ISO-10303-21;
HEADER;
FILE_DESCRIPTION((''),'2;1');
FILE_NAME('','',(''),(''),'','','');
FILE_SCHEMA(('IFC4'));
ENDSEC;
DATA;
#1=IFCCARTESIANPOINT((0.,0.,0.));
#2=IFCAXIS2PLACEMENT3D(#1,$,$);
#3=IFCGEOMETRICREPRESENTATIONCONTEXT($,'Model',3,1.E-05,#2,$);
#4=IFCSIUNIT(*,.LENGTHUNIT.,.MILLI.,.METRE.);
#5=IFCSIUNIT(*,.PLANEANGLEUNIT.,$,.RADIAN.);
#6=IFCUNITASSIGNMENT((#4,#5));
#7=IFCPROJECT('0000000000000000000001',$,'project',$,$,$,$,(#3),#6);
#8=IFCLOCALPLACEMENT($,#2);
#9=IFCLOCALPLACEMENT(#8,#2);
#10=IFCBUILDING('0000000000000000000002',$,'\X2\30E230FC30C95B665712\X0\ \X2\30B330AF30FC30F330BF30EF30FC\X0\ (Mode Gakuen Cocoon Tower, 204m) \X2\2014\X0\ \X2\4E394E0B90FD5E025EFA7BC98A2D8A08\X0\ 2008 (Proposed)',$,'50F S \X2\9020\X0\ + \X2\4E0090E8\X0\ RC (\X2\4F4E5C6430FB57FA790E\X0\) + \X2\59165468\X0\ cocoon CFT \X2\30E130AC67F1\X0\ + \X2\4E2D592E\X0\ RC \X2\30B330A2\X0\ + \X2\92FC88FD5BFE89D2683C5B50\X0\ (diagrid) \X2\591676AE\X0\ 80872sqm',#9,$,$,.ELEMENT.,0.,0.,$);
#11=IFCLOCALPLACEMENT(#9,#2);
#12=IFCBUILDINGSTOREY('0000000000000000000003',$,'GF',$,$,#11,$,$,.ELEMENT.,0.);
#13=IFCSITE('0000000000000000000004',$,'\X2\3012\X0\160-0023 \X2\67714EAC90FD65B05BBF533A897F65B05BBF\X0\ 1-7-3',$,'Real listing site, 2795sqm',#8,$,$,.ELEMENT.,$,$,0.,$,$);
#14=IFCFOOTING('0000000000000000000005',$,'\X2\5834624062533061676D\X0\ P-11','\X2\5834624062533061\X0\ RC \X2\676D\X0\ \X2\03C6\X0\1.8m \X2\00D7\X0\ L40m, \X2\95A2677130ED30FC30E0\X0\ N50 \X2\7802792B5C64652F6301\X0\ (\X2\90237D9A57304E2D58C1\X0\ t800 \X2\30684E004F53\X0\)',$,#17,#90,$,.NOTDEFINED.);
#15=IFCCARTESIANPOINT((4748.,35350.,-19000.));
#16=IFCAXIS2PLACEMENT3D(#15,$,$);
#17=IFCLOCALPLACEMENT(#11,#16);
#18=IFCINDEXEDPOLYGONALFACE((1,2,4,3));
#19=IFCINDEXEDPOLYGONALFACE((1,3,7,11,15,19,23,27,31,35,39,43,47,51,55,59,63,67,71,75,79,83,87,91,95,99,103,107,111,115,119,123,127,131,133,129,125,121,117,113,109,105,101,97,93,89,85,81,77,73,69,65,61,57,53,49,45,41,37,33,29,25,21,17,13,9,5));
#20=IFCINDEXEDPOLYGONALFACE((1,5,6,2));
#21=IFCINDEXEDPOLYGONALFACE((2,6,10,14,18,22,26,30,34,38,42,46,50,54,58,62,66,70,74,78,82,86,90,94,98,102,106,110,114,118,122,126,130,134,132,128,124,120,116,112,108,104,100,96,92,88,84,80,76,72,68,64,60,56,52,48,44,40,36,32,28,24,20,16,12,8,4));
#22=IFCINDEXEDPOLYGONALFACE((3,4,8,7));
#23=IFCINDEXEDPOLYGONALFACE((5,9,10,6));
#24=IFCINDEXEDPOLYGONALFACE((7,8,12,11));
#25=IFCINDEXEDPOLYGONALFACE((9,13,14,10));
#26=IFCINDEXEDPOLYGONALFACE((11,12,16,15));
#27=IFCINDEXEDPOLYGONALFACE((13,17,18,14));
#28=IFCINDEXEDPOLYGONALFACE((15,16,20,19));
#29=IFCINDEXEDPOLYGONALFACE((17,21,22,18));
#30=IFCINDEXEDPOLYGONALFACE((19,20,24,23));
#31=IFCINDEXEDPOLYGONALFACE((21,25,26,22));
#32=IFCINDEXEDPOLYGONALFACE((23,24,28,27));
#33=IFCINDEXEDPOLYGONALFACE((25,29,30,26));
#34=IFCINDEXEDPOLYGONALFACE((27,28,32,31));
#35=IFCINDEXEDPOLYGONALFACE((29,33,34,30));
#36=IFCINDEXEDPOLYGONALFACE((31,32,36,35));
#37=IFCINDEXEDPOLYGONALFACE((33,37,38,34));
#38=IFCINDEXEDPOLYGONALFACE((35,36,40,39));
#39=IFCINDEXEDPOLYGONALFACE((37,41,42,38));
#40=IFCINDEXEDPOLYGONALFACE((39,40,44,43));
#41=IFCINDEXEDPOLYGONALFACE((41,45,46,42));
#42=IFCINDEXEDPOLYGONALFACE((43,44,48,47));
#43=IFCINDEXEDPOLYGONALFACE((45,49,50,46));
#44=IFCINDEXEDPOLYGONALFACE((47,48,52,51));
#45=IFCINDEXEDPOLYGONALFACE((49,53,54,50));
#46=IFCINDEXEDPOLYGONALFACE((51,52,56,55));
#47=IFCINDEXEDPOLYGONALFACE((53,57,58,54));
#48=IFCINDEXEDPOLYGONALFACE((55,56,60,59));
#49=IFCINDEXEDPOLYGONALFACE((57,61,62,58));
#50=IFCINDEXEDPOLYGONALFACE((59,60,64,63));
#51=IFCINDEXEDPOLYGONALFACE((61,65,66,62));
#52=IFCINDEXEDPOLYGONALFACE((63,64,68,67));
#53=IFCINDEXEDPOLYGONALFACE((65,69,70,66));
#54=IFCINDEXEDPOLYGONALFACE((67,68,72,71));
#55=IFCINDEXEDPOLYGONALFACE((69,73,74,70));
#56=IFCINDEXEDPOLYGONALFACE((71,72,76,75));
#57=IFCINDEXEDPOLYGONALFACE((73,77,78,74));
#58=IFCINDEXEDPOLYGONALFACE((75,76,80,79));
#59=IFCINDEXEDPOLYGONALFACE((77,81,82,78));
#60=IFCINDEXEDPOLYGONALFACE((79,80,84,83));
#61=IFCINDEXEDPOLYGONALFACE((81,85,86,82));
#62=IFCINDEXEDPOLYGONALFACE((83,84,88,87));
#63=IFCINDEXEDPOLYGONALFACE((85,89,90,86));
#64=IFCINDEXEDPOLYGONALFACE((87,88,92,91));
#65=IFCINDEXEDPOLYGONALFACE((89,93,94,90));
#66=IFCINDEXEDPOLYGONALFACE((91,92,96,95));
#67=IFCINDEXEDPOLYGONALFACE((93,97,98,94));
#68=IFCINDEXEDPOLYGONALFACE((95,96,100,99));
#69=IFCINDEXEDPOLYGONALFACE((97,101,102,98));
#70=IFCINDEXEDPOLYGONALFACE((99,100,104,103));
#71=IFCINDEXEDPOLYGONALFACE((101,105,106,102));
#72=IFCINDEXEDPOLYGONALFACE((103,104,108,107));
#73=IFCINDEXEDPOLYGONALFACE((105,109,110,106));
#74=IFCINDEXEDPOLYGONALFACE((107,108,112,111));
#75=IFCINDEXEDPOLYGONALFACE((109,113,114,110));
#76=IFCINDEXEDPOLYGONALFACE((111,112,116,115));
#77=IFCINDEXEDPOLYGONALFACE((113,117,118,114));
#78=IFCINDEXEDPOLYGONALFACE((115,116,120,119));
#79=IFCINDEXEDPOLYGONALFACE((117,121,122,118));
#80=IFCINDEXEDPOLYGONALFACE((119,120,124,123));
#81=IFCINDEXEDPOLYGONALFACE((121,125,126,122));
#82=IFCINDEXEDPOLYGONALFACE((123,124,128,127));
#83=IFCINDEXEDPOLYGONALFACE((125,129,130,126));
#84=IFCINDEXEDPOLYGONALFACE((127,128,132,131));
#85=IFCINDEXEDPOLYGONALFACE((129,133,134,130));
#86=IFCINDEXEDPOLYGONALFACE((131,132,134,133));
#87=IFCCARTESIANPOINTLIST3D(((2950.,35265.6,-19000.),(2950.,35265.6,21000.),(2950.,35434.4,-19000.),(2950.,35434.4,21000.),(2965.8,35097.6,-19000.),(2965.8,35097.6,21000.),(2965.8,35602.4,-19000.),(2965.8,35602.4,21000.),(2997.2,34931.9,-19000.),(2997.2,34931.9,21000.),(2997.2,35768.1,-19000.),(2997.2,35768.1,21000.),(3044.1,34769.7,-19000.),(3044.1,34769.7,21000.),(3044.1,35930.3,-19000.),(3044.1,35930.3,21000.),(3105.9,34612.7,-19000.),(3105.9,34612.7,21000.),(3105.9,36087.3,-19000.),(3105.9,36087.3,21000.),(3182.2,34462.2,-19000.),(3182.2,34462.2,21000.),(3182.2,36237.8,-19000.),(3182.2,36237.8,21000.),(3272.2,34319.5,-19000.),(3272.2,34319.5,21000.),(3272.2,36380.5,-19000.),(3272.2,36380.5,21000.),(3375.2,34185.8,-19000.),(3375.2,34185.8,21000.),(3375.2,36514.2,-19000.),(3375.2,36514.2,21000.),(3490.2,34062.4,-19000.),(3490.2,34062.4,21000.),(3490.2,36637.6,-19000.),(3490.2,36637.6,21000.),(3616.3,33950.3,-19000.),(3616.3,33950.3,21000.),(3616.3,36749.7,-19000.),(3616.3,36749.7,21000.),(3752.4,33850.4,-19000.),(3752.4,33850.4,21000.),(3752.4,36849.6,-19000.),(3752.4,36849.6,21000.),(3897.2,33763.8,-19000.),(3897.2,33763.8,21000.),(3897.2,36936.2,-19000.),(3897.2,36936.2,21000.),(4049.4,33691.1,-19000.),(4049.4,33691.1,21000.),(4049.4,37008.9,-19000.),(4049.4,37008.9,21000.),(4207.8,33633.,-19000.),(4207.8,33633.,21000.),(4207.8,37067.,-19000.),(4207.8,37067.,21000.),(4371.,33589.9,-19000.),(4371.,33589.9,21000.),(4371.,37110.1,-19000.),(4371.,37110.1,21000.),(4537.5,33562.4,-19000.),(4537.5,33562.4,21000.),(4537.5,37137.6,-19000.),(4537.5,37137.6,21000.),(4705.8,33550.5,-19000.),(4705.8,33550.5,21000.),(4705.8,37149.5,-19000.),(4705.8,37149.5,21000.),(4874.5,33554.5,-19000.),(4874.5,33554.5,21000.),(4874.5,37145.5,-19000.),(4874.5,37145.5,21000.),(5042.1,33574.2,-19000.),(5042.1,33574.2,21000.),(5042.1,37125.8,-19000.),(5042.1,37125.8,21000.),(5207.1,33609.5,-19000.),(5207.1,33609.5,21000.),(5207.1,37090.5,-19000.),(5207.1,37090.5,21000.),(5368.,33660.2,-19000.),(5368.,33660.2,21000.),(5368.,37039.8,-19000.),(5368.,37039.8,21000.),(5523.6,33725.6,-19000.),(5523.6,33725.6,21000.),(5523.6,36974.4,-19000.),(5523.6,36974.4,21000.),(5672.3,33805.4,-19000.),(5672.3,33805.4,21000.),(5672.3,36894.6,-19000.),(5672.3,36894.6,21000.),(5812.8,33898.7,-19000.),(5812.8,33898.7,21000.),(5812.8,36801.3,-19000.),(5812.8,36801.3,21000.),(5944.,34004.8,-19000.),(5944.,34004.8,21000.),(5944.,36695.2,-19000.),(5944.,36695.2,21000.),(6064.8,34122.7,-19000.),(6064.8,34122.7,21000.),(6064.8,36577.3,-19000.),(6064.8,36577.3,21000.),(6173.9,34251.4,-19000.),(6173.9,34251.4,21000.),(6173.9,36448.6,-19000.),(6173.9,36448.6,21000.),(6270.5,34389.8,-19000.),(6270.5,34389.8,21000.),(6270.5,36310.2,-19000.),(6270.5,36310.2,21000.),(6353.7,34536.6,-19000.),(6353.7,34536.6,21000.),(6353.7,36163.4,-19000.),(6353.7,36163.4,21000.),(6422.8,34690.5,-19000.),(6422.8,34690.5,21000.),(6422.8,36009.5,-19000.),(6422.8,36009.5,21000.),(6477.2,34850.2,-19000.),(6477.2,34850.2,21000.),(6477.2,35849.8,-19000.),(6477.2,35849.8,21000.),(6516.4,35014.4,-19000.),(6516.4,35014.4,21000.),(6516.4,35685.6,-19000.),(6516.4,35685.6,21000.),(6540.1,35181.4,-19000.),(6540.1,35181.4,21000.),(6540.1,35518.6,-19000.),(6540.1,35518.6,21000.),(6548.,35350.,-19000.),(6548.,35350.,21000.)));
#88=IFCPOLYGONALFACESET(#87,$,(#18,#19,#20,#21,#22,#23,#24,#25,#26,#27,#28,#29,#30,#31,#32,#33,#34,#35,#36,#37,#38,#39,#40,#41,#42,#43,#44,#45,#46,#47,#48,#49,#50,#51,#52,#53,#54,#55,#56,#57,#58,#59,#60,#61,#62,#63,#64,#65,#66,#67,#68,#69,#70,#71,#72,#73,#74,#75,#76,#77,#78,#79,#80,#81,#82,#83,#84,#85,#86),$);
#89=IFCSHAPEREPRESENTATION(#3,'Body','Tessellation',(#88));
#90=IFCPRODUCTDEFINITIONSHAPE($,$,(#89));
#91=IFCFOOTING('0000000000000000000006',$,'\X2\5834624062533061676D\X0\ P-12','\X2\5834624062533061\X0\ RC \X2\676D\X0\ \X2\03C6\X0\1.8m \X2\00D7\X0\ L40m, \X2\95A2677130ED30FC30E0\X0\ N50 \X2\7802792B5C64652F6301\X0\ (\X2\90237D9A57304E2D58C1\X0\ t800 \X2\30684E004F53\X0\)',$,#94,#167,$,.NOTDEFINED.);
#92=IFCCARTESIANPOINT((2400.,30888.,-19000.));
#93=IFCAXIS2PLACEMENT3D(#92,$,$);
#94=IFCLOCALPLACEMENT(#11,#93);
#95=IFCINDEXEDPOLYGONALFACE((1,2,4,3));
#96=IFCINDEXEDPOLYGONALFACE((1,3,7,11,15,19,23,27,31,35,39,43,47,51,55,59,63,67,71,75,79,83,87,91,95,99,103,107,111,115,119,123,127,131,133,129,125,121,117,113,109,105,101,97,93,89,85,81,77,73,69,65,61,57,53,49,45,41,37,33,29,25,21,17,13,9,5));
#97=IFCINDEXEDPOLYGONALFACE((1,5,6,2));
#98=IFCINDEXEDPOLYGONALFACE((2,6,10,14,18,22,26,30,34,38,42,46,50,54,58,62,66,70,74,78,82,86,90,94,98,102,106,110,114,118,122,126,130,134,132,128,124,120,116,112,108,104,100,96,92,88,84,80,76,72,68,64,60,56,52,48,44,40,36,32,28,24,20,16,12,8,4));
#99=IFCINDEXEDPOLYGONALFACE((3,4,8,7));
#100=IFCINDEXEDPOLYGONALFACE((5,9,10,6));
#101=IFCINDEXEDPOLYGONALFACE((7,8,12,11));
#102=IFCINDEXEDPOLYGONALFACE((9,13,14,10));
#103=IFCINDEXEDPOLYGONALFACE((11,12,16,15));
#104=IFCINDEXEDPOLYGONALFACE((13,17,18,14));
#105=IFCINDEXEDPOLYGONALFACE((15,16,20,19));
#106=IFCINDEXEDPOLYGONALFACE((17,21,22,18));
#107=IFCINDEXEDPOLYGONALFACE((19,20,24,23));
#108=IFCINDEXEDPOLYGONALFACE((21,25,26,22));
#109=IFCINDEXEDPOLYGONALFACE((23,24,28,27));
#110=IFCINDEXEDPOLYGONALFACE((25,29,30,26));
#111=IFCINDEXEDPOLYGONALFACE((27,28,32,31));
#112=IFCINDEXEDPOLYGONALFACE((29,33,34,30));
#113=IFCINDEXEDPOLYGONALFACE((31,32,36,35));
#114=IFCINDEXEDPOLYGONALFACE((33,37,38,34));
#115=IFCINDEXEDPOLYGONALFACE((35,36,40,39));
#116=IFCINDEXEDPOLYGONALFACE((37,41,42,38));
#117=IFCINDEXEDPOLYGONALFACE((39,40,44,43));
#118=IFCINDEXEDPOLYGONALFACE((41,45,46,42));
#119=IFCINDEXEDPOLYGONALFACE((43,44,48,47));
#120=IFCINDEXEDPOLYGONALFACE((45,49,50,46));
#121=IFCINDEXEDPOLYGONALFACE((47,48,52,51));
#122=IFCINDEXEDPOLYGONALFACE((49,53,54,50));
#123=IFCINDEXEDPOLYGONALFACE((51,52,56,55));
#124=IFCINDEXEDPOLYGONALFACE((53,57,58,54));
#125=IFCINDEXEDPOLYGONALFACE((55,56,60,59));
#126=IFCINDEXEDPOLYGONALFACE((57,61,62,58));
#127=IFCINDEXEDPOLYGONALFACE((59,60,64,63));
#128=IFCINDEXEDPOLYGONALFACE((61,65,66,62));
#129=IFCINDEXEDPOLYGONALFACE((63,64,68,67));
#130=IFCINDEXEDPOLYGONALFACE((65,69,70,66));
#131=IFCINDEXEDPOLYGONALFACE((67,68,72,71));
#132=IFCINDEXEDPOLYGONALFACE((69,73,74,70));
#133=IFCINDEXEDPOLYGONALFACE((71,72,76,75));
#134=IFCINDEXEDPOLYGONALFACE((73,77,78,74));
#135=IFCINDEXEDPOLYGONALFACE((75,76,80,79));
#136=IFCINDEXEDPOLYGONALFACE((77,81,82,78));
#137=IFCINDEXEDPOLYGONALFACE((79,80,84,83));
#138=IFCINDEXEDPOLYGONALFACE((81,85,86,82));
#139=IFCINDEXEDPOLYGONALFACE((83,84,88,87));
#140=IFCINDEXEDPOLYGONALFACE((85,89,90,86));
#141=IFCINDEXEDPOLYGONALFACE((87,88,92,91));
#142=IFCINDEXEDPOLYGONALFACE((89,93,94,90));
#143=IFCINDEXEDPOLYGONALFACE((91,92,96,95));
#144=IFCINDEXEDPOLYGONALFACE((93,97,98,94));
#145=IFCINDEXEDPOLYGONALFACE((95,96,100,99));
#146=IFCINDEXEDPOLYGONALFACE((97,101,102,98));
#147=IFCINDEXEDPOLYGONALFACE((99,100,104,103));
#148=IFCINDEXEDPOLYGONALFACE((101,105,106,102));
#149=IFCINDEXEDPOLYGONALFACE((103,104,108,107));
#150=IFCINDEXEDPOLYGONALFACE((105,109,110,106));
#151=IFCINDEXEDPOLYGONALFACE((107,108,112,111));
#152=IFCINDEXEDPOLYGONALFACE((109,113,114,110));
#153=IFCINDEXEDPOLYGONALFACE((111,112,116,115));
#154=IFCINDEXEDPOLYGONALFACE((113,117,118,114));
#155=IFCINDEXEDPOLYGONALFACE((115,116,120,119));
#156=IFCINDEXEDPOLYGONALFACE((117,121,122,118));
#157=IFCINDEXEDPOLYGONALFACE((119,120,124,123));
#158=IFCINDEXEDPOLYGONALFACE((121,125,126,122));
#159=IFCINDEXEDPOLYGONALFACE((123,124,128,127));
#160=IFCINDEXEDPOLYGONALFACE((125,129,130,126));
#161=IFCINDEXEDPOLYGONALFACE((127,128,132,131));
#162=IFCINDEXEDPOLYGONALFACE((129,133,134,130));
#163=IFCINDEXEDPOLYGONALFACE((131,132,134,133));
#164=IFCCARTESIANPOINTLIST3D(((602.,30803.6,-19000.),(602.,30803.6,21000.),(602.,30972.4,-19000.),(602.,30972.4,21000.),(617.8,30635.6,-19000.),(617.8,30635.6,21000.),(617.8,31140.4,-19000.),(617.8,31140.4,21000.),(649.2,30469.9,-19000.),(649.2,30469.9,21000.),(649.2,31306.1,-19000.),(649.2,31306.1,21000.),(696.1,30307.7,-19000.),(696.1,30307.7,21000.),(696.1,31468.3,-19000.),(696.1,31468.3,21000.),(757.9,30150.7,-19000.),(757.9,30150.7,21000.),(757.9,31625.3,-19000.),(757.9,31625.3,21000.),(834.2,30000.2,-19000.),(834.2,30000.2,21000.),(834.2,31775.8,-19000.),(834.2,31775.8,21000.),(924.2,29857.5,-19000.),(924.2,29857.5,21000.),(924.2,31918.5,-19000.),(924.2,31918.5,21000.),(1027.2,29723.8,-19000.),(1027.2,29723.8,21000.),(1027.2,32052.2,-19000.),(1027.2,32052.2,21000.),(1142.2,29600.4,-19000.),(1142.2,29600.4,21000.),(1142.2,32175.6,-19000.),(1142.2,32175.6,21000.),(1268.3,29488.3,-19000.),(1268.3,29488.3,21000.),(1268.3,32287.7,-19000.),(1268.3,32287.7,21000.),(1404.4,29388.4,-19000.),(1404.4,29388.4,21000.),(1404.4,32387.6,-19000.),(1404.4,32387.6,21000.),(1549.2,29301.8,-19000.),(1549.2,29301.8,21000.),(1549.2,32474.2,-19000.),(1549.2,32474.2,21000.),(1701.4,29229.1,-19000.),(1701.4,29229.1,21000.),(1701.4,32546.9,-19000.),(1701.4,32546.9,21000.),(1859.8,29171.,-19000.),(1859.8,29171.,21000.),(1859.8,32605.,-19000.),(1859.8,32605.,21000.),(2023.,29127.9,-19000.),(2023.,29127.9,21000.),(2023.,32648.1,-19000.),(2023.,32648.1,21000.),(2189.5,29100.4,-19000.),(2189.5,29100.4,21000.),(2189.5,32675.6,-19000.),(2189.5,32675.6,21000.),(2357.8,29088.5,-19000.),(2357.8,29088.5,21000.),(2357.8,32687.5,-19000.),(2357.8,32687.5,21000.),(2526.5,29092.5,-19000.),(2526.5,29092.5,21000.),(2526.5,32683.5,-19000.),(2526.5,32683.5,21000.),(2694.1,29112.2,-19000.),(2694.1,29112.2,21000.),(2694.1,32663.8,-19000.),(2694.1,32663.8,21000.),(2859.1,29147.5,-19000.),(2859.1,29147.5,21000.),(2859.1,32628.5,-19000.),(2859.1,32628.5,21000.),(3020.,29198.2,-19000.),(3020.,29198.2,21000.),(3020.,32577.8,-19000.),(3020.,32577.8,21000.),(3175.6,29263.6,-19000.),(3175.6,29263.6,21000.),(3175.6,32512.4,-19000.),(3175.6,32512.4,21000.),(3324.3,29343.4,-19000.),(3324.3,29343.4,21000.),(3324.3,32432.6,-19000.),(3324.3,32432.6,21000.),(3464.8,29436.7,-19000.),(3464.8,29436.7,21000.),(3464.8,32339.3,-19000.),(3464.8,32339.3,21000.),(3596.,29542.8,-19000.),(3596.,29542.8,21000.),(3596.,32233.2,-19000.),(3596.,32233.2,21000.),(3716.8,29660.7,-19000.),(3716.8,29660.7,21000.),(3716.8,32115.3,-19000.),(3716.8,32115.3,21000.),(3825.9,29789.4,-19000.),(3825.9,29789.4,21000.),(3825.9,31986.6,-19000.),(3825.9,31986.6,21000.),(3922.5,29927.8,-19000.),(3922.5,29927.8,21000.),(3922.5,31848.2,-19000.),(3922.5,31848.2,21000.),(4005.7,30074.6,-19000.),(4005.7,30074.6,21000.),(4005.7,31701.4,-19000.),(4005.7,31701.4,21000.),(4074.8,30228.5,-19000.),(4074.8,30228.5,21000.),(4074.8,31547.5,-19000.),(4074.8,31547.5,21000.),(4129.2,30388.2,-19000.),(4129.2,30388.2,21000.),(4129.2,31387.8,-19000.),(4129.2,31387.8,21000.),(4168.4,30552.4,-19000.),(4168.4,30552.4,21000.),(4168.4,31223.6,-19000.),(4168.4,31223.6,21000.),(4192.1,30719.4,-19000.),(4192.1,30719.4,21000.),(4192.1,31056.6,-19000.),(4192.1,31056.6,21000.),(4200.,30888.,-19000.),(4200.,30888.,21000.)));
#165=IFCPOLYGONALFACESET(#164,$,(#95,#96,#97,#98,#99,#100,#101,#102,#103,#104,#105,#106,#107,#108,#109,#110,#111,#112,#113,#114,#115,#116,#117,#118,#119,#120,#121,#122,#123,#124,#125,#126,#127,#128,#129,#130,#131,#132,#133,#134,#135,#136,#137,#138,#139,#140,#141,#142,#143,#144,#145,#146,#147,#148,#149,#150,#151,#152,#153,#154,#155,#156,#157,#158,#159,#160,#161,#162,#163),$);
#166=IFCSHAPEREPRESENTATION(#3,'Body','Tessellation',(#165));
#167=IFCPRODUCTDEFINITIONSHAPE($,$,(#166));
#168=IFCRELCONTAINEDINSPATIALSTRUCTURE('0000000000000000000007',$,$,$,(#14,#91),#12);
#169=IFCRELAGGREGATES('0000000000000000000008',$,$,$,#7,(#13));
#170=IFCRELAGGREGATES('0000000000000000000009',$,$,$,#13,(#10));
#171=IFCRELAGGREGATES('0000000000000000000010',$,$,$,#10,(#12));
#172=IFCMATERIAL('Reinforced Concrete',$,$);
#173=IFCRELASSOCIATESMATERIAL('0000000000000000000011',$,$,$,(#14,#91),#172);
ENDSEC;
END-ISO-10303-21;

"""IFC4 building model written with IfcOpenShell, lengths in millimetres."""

from ifc_helpers import new_model, si_unit, frame, origin, origin_2d, place, context, project, spatial, circle, extrude, material, element, save


model = new_model("IFC4")

# Units and contexts
model_context = context("Model", 3, precision=1e-05, world=origin())
ifc_project = project(units=[si_unit("LENGTHUNIT", "METRE", prefix="MILLI"), si_unit("PLANEANGLEUNIT", "RADIAN")], contexts=[model_context])

# Site, building, storey
site_placement = place(None, origin())
site = spatial("IfcSite", under=ifc_project, at=site_placement, Name="〒160-0023 東京都新宿区西新宿 1-7-3", ObjectType="Real listing site, 2795sqm", CompositionType="ELEMENT", RefElevation=0.0)
building_placement = place(site_placement, origin())
building = spatial("IfcBuilding", under=site, at=building_placement, Name="モード学園 コクーンタワー (Mode Gakuen Cocoon Tower, 204m) — 丹下都市建築設計 2008 (Proposed)", ObjectType="50F S 造 + 一部 RC (低層・基礎) + 外周 cocoon CFT メガ柱 + 中央 RC コア + 鋼製対角格子 (diagrid) 外皮 80872sqm", CompositionType="ELEMENT", ElevationOfRefHeight=0.0, ElevationOfTerrain=0.0)
storey_placement = place(building_placement, origin())
storey = spatial("IfcBuildingStorey", under=building, at=storey_placement, Name="GF", CompositionType="ELEMENT", Elevation=0.0)

# Footings
ifc_material_1 = material(Name="Reinforced Concrete")
footing_1_placement = place(storey_placement, frame((4748.0, 35350.0, -19000.0)))
element("IfcFooting", 1, at=footing_1_placement, inside=storey, material=ifc_material_1, Name="場所打ち杭 P-11", Description="場所打ち RC 杭 φ1.8m × L40m, 関東ローム N50 砂礫層支持 (連続地中壁 t800 と一体)", PredefinedType="NOTDEFINED", context=model_context, shape_type="SweptSolid", body=[
    extrude(circle(Radius=1800.0, at=origin_2d()), frame((4748.0, 35350.0, -19000.0)), (0.0, 0.0, 1.0), 40000.0),
])
footing_2_placement = place(storey_placement, frame((2400.0, 30888.0, -19000.0)))
element("IfcFooting", 2, at=footing_2_placement, inside=storey, material=ifc_material_1, Name="場所打ち杭 P-12", Description="場所打ち RC 杭 φ1.8m × L40m, 関東ローム N50 砂礫層支持 (連続地中壁 t800 と一体)", PredefinedType="NOTDEFINED", context=model_context, shape_type="SweptSolid", body=[
    extrude(circle(Radius=1800.0, at=origin_2d()), frame((2400.0, 30888.0, -19000.0)), (0.0, 0.0, 1.0), 40000.0),
])

save(model, "model.ifc")
